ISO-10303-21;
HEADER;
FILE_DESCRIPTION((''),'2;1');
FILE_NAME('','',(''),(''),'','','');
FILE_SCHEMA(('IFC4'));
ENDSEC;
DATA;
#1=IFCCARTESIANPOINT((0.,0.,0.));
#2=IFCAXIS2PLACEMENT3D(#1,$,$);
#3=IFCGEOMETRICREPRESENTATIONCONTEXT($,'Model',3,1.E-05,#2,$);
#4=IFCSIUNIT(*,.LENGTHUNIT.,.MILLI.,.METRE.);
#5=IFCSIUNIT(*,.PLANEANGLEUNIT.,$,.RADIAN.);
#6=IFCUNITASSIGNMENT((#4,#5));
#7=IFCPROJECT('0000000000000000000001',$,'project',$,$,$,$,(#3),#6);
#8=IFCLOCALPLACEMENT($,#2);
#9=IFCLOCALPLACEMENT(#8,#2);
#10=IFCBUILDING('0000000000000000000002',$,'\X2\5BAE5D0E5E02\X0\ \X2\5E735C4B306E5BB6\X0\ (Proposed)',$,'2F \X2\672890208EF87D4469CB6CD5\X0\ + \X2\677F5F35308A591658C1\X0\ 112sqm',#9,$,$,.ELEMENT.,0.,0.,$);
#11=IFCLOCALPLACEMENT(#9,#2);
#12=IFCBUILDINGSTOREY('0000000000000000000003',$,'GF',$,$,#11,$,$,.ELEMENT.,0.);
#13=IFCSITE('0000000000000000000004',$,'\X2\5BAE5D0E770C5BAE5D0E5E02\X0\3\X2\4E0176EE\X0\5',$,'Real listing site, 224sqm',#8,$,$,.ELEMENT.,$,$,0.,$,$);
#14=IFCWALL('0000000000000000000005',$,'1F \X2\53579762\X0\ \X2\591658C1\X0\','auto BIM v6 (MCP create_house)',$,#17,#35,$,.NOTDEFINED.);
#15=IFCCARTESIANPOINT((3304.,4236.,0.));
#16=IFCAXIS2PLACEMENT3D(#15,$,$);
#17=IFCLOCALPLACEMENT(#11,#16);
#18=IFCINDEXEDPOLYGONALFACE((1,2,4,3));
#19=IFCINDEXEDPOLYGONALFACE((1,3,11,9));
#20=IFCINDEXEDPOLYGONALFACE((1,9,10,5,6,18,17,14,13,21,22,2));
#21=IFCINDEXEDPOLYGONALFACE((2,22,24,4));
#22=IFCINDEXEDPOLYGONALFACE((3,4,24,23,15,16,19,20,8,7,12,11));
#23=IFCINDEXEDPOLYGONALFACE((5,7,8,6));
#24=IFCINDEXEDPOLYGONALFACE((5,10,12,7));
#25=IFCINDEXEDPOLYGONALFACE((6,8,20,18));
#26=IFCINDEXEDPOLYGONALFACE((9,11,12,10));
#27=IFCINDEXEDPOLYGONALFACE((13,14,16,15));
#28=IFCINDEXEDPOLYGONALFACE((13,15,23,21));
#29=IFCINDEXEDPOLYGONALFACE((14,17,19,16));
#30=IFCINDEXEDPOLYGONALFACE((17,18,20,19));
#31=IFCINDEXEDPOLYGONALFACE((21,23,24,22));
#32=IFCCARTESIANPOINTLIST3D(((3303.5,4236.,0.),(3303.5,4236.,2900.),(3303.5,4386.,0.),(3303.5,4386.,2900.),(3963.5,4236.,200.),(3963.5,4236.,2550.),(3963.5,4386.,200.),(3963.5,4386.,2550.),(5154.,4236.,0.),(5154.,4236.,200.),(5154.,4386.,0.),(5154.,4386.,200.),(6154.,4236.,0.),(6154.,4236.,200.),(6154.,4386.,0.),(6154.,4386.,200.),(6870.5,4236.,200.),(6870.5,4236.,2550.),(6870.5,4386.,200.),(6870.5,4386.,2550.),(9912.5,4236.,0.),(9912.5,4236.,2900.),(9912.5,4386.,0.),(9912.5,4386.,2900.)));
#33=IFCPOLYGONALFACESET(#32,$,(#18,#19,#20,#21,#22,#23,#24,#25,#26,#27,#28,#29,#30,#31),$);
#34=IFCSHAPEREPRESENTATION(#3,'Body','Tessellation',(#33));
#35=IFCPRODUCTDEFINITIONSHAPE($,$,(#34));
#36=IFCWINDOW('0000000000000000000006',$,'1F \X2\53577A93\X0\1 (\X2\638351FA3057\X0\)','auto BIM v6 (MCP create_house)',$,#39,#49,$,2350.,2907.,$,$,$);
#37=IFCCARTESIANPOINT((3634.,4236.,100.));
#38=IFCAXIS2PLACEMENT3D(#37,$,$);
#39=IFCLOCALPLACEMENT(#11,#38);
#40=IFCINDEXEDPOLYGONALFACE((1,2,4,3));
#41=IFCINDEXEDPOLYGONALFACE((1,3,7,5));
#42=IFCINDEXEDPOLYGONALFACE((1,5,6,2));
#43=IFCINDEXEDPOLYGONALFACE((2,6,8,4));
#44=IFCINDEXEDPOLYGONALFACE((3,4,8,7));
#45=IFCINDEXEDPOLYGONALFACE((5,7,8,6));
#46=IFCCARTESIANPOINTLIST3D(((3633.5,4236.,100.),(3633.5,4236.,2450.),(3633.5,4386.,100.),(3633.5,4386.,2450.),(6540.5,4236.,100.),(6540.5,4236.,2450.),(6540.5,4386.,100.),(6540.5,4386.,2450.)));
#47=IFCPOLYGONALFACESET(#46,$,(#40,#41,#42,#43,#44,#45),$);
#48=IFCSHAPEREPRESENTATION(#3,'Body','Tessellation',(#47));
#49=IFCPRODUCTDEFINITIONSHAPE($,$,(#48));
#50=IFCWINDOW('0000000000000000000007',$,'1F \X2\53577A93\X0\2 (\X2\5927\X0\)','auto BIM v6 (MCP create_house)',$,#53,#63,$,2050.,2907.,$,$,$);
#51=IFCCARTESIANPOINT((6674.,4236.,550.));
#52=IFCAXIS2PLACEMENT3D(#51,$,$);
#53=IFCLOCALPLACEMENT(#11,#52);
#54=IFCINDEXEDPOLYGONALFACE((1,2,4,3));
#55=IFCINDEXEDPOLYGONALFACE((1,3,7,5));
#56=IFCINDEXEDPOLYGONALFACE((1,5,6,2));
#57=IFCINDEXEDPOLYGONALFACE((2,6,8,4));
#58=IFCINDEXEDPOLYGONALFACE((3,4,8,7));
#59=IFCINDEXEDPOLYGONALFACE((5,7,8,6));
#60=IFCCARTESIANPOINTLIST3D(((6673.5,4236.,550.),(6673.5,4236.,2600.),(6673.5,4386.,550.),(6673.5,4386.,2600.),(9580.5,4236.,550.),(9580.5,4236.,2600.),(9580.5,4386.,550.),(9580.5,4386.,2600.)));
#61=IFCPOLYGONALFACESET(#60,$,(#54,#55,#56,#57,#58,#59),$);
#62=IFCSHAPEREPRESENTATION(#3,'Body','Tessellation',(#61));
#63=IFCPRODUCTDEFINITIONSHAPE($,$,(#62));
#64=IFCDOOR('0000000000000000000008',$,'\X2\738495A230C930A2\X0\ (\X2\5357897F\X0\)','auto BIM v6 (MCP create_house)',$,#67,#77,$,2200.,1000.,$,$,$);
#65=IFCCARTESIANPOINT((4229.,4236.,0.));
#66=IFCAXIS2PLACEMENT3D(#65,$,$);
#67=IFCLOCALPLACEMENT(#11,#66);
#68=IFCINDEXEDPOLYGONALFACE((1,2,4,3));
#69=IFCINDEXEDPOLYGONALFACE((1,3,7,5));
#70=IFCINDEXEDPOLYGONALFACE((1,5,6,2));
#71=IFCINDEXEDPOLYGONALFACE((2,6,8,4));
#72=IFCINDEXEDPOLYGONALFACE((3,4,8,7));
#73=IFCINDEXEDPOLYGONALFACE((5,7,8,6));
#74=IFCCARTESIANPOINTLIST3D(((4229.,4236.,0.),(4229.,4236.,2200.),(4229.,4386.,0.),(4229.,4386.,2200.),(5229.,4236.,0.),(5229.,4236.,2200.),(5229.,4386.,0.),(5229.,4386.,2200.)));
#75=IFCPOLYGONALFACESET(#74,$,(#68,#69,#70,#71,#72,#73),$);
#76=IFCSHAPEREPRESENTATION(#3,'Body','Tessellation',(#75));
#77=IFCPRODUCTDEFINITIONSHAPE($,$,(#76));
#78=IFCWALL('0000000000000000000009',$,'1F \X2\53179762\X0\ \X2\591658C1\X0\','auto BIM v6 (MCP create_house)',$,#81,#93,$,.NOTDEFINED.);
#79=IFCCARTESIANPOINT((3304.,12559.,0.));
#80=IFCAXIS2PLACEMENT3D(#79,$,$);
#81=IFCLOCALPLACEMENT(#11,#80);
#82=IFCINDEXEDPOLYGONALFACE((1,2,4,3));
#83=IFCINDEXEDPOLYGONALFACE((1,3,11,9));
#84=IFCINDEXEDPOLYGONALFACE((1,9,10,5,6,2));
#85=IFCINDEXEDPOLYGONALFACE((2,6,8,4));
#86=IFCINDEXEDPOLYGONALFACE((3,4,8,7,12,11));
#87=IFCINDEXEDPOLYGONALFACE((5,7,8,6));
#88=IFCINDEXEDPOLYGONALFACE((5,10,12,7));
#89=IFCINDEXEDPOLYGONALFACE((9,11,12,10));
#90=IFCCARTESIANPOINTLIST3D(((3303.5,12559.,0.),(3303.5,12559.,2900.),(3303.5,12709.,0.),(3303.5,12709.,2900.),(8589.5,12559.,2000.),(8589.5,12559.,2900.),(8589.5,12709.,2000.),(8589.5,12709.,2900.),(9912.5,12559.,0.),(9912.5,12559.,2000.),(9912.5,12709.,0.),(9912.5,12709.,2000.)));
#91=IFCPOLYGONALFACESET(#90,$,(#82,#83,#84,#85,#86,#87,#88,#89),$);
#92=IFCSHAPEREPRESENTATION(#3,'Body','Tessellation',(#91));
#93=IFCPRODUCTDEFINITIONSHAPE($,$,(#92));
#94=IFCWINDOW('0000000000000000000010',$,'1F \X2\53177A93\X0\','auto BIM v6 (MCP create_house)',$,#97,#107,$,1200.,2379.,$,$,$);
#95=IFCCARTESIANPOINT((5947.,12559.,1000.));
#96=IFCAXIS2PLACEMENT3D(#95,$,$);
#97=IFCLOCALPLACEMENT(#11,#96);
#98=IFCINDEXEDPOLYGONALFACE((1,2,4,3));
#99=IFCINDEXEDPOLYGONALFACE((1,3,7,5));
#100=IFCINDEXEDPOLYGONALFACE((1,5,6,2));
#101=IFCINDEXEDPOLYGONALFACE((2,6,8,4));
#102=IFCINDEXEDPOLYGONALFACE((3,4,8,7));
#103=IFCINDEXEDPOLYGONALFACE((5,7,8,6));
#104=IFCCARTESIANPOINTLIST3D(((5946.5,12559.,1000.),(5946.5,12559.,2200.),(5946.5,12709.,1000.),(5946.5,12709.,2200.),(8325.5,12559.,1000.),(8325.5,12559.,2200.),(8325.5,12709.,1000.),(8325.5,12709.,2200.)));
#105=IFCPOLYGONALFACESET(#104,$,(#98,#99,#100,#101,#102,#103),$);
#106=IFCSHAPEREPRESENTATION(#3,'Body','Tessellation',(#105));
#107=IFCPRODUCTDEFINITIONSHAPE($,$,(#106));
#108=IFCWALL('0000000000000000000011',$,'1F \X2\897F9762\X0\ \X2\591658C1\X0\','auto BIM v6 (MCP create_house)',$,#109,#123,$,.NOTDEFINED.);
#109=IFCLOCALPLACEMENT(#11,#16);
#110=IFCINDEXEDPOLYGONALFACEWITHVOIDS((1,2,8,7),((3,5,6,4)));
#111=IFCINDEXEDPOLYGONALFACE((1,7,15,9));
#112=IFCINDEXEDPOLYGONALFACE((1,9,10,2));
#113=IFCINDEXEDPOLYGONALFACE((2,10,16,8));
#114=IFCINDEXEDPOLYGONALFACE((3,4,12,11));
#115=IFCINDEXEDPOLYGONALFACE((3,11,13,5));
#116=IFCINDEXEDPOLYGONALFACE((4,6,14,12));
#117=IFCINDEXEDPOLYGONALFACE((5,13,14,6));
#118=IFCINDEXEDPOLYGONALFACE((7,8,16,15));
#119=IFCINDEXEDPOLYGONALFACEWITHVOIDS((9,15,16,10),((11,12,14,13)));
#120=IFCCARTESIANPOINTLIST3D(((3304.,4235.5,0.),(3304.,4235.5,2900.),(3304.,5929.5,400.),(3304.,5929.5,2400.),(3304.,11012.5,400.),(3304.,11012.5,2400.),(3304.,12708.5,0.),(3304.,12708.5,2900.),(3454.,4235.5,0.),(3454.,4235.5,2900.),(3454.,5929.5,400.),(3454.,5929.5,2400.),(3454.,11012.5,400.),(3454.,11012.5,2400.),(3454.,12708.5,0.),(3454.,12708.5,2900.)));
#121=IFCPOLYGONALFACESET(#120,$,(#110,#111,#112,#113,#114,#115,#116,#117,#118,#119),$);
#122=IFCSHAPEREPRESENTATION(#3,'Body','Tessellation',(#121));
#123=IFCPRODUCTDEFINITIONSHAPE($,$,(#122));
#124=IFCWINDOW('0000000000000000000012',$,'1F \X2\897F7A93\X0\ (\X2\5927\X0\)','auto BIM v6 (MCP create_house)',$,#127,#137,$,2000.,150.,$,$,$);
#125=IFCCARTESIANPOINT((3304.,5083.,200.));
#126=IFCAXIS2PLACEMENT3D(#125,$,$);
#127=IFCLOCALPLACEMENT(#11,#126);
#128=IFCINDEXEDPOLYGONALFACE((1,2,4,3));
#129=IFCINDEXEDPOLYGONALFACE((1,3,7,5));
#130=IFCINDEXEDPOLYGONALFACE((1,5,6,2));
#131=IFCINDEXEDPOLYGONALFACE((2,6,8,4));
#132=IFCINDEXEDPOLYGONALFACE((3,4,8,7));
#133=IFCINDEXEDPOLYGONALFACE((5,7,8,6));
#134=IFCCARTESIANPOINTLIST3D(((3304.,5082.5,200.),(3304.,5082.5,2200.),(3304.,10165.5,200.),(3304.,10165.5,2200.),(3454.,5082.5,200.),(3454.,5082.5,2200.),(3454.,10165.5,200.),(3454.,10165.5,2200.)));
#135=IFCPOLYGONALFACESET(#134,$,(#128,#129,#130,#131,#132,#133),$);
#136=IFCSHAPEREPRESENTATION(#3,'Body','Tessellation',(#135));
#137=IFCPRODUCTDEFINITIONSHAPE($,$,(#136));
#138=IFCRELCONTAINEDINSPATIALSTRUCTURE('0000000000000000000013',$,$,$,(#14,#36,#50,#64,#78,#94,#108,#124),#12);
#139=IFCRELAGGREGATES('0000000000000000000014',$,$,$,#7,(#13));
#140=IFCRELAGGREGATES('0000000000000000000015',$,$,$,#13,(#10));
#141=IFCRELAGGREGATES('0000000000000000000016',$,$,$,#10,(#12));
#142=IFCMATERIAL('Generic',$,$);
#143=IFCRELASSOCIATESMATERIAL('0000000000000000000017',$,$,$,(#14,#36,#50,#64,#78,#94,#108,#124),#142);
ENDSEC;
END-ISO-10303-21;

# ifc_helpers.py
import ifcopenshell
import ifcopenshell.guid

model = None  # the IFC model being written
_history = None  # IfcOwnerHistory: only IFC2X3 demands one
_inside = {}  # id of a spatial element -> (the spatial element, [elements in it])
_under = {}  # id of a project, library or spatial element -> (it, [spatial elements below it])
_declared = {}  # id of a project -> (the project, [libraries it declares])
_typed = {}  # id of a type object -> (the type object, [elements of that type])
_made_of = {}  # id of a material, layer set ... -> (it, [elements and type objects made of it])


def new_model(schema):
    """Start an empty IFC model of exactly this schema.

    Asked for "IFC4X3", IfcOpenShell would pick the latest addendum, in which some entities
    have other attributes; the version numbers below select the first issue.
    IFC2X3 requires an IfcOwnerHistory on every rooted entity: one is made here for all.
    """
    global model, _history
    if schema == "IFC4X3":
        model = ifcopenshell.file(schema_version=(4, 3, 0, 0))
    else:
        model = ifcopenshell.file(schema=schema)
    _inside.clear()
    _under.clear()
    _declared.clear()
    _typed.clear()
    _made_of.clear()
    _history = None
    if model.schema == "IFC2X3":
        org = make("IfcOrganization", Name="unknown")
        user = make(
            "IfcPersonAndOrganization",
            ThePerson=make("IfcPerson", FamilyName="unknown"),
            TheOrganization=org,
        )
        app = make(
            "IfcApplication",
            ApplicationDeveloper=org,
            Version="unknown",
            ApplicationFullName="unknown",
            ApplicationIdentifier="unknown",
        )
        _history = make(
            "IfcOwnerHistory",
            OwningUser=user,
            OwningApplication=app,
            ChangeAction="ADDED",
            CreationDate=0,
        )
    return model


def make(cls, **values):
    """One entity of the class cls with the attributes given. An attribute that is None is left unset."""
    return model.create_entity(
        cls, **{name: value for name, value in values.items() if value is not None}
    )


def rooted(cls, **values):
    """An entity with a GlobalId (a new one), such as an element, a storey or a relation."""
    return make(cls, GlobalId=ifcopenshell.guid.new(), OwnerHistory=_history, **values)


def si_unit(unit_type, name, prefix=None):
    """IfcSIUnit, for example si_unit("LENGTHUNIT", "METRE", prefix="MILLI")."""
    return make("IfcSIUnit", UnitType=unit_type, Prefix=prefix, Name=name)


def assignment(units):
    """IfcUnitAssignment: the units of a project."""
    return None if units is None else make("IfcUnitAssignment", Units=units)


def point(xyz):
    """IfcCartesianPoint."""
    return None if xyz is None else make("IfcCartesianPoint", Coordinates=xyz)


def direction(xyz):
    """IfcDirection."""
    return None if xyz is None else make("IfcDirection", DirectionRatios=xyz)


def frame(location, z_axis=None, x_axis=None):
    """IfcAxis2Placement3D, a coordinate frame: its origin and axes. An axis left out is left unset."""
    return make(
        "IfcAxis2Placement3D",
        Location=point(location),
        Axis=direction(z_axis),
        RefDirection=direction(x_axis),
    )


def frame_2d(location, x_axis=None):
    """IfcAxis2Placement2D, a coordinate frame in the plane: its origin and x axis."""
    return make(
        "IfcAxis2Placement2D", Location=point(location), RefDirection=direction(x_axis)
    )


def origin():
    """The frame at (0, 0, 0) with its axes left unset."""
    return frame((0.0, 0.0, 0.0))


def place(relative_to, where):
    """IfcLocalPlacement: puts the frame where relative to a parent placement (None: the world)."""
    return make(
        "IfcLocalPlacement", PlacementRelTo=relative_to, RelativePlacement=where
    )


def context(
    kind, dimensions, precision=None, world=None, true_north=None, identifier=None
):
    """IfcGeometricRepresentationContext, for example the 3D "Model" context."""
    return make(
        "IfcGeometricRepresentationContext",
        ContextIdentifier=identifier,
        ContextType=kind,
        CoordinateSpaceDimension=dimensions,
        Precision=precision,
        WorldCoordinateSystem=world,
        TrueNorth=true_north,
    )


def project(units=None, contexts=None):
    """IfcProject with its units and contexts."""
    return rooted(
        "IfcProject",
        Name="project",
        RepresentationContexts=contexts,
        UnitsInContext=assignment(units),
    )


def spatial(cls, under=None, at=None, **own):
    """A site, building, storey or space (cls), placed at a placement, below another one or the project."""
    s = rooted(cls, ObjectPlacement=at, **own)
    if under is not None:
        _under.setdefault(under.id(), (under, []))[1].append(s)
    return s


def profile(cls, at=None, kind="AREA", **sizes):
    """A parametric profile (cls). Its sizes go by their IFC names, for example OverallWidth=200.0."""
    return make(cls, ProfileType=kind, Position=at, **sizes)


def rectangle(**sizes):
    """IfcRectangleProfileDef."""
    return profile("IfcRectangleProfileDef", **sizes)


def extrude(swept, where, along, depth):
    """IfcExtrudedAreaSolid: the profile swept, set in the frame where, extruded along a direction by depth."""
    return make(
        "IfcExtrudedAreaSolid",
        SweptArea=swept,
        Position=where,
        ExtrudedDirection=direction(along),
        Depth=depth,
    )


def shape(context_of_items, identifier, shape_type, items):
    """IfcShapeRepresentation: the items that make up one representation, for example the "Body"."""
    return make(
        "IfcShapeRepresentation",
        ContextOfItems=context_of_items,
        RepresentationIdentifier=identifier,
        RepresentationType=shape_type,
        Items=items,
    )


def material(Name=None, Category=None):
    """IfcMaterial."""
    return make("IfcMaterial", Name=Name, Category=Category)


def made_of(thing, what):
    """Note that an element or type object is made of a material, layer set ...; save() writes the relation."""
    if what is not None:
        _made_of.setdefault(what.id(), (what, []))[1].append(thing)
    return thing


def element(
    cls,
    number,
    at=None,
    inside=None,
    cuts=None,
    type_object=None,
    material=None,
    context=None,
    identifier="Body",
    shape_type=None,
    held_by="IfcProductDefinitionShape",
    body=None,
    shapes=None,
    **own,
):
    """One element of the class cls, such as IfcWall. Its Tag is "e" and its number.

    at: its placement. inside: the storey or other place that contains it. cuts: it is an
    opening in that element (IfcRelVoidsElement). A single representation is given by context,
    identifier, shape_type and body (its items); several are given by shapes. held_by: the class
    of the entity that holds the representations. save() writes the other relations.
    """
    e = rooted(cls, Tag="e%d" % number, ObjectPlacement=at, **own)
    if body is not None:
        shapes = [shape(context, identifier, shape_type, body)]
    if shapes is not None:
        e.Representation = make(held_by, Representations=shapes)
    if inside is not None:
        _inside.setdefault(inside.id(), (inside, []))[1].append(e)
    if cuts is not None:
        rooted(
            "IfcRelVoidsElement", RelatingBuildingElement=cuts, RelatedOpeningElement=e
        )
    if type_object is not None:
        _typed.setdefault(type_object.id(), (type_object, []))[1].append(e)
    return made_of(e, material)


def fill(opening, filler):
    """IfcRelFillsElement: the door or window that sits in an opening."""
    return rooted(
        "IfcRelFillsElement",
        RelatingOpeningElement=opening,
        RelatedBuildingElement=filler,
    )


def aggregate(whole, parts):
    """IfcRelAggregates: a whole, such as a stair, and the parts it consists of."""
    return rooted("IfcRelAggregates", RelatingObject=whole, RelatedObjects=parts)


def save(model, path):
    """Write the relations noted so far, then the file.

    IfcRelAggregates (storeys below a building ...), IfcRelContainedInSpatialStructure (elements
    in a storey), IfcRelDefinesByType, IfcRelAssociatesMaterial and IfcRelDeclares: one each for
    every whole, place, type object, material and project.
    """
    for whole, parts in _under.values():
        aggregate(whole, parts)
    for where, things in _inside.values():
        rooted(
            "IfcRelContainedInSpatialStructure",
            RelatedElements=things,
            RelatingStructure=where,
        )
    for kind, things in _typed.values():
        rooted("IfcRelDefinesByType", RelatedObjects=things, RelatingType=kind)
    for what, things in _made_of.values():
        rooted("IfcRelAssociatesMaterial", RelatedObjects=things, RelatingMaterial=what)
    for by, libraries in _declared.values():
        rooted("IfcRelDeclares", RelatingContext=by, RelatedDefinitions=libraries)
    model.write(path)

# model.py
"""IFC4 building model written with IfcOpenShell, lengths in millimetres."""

from ifc_helpers import new_model, si_unit, frame, frame_2d, origin, place, context, project, spatial, rectangle, extrude, material, element, fill, save


model = new_model("IFC4")

# Units and contexts
model_context = context("Model", 3, precision=1e-05, world=origin())
ifc_project = project(units=[si_unit("LENGTHUNIT", "METRE", prefix="MILLI"), si_unit("PLANEANGLEUNIT", "RADIAN")], contexts=[model_context])

# Site, building, storey
site_placement = place(None, origin())
site = spatial("IfcSite", under=ifc_project, at=site_placement, Name="宮崎県宮崎市3丁目5", ObjectType="Real listing site, 224sqm", CompositionType="ELEMENT", RefElevation=0.0)
building_placement = place(site_placement, origin())
building = spatial("IfcBuilding", under=site, at=building_placement, Name="宮崎市 平屋の家 (Proposed)", ObjectType="2F 木造軸組構法 + 板張り外壁 112sqm", CompositionType="ELEMENT", ElevationOfRefHeight=0.0, ElevationOfTerrain=0.0)
storey_placement = place(building_placement, origin())
storey = spatial("IfcBuildingStorey", under=building, at=storey_placement, Name="GF", CompositionType="ELEMENT", Elevation=0.0)

# Shared definitions
ifc_material = material(Name="Generic")

# Wall, openings, windows, door
wall_1_placement = place(storey_placement, frame((3304.0, 4236.0, 0.0)))
wall_1 = element("IfcWall", 1, at=wall_1_placement, inside=storey, material=ifc_material, Name="1F 南面 外壁", Description="auto BIM v6 (MCP create_house)", PredefinedType="NOTDEFINED", context=model_context, shape_type="SweptSolid", body=[
    extrude(rectangle(XDim=6609.0, YDim=150.0, at=frame_2d((3304.0, 75.0))), frame((3304.0, 4236.0, 0.0)), (0.0, 0.0, 1.0), 2900.0),
])
opening_1_placement = place(storey_placement, frame((3634.0, 4236.0, 100.0)))
opening_1 = element("IfcOpeningElement", 2, at=opening_1_placement, cuts=wall_1, PredefinedType="NOTDEFINED", context=model_context, shape_type="SweptSolid", body=[
    extrude(rectangle(XDim=2907.0, YDim=150.0, at=frame_2d((1453.0, 75.0))), frame((3634.0, 4236.0, 100.0)), (0.0, 0.0, 1.0), 2350.0),
])
opening_2_placement = place(storey_placement, frame((6674.0, 4236.0, 550.0)))
opening_2 = element("IfcOpeningElement", 3, at=opening_2_placement, cuts=wall_1, PredefinedType="NOTDEFINED", context=model_context, shape_type="SweptSolid", body=[
    extrude(rectangle(XDim=2907.0, YDim=150.0, at=frame_2d((1453.0, 75.0))), frame((6674.0, 4236.0, 550.0)), (0.0, 0.0, 1.0), 2050.0),
])
opening_3_placement = place(storey_placement, frame((4229.0, 4236.0, 0.0)))
opening_3 = element("IfcOpeningElement", 4, at=opening_3_placement, cuts=wall_1, PredefinedType="NOTDEFINED", context=model_context, shape_type="SweptSolid", body=[
    extrude(rectangle(XDim=1000.0, YDim=150.0, at=frame_2d((500.0, 75.0))), frame((4229.0, 4236.0, 0.0)), (0.0, 0.0, 1.0), 2200.0),
])
window_1_placement = place(storey_placement, frame((3634.0, 4236.0, 100.0)))
window_1 = element("IfcWindow", 5, at=window_1_placement, inside=storey, material=ifc_material, Name="1F 南窓1 (掃出し)", Description="auto BIM v6 (MCP create_house)", OverallHeight=2350.0, OverallWidth=2907.0, context=model_context, shape_type="SweptSolid", body=[
    extrude(rectangle(XDim=2907.0, YDim=150.0, at=frame_2d((1453.0, 75.0))), frame((3634.0, 4236.0, 100.0)), (0.0, 0.0, 1.0), 2350.0),
])
fill(opening_1, window_1)
window_2_placement = place(storey_placement, frame((6674.0, 4236.0, 550.0)))
window_2 = element("IfcWindow", 6, at=window_2_placement, inside=storey, material=ifc_material, Name="1F 南窓2 (大)", Description="auto BIM v6 (MCP create_house)", OverallHeight=2050.0, OverallWidth=2907.0, context=model_context, shape_type="SweptSolid", body=[
    extrude(rectangle(XDim=2907.0, YDim=150.0, at=frame_2d((1453.0, 75.0))), frame((6674.0, 4236.0, 550.0)), (0.0, 0.0, 1.0), 2050.0),
])
fill(opening_2, window_2)
door_1_placement = place(storey_placement, frame((4229.0, 4236.0, 0.0)))
door_1 = element("IfcDoor", 7, at=door_1_placement, inside=storey, material=ifc_material, Name="玄関ドア (南西)", Description="auto BIM v6 (MCP create_house)", OverallHeight=2200.0, OverallWidth=1000.0, context=model_context, shape_type="SweptSolid", body=[
    extrude(rectangle(XDim=1000.0, YDim=150.0, at=frame_2d((500.0, 75.0))), frame((4229.0, 4236.0, 0.0)), (0.0, 0.0, 1.0), 2200.0),
])
fill(opening_3, door_1)

# Walls, openings, windows
wall_2_placement = place(storey_placement, frame((3304.0, 12559.0, 0.0)))
wall_2 = element("IfcWall", 8, at=wall_2_placement, inside=storey, material=ifc_material, Name="1F 北面 外壁", Description="auto BIM v6 (MCP create_house)", PredefinedType="NOTDEFINED", context=model_context, shape_type="SweptSolid", body=[
    extrude(rectangle(XDim=6609.0, YDim=150.0, at=frame_2d((3304.0, 75.0))), frame((3304.0, 12559.0, 0.0)), (0.0, 0.0, 1.0), 2900.0),
])
opening_4_placement = place(storey_placement, frame((5947.0, 12559.0, 1000.0)))
opening_4 = element("IfcOpeningElement", 9, at=opening_4_placement, cuts=wall_2, PredefinedType="NOTDEFINED", context=model_context, shape_type="SweptSolid", body=[
    extrude(rectangle(XDim=2379.0, YDim=150.0, at=frame_2d((1189.0, 75.0))), frame((5947.0, 12559.0, 1000.0)), (0.0, 0.0, 1.0), 1200.0),
])
window_3_placement = place(storey_placement, frame((5947.0, 12559.0, 1000.0)))
window_3 = element("IfcWindow", 10, at=window_3_placement, inside=storey, material=ifc_material, Name="1F 北窓", Description="auto BIM v6 (MCP create_house)", OverallHeight=1200.0, OverallWidth=2379.0, context=model_context, shape_type="SweptSolid", body=[
    extrude(rectangle(XDim=2379.0, YDim=150.0, at=frame_2d((1189.0, 75.0))), frame((5947.0, 12559.0, 1000.0)), (0.0, 0.0, 1.0), 1200.0),
])
fill(opening_4, window_3)
wall_3_placement = place(storey_placement, frame((3304.0, 4236.0, 0.0)))
wall_3 = element("IfcWall", 11, at=wall_3_placement, inside=storey, material=ifc_material, Name="1F 西面 外壁", Description="auto BIM v6 (MCP create_house)", PredefinedType="NOTDEFINED", context=model_context, shape_type="SweptSolid", body=[
    extrude(rectangle(XDim=150.0, YDim=8473.0, at=frame_2d((75.0, 4236.0))), frame((3304.0, 4236.0, 0.0)), (0.0, 0.0, 1.0), 2900.0),
])
opening_5_placement = place(storey_placement, frame((3304.0, 5083.0, 200.0)))
opening_5 = element("IfcOpeningElement", 12, at=opening_5_placement, cuts=wall_3, PredefinedType="NOTDEFINED", context=model_context, shape_type="SweptSolid", body=[
    extrude(rectangle(XDim=150.0, YDim=5083.0, at=frame_2d((75.0, 2541.0))), frame((3304.0, 5083.0, 200.0)), (0.0, 0.0, 1.0), 2000.0),
])
window_4_placement = place(storey_placement, frame((3304.0, 5083.0, 200.0)))
window_4 = element("IfcWindow", 13, at=window_4_placement, inside=storey, material=ifc_material, Name="1F 西窓 (大)", Description="auto BIM v6 (MCP create_house)", OverallHeight=2000.0, OverallWidth=150.0, context=model_context, shape_type="SweptSolid", body=[
    extrude(rectangle(XDim=150.0, YDim=5083.0, at=frame_2d((75.0, 2541.0))), frame((3304.0, 5083.0, 200.0)), (0.0, 0.0, 1.0), 2000.0),
])
fill(opening_5, window_4)

save(model, "model.ifc")
